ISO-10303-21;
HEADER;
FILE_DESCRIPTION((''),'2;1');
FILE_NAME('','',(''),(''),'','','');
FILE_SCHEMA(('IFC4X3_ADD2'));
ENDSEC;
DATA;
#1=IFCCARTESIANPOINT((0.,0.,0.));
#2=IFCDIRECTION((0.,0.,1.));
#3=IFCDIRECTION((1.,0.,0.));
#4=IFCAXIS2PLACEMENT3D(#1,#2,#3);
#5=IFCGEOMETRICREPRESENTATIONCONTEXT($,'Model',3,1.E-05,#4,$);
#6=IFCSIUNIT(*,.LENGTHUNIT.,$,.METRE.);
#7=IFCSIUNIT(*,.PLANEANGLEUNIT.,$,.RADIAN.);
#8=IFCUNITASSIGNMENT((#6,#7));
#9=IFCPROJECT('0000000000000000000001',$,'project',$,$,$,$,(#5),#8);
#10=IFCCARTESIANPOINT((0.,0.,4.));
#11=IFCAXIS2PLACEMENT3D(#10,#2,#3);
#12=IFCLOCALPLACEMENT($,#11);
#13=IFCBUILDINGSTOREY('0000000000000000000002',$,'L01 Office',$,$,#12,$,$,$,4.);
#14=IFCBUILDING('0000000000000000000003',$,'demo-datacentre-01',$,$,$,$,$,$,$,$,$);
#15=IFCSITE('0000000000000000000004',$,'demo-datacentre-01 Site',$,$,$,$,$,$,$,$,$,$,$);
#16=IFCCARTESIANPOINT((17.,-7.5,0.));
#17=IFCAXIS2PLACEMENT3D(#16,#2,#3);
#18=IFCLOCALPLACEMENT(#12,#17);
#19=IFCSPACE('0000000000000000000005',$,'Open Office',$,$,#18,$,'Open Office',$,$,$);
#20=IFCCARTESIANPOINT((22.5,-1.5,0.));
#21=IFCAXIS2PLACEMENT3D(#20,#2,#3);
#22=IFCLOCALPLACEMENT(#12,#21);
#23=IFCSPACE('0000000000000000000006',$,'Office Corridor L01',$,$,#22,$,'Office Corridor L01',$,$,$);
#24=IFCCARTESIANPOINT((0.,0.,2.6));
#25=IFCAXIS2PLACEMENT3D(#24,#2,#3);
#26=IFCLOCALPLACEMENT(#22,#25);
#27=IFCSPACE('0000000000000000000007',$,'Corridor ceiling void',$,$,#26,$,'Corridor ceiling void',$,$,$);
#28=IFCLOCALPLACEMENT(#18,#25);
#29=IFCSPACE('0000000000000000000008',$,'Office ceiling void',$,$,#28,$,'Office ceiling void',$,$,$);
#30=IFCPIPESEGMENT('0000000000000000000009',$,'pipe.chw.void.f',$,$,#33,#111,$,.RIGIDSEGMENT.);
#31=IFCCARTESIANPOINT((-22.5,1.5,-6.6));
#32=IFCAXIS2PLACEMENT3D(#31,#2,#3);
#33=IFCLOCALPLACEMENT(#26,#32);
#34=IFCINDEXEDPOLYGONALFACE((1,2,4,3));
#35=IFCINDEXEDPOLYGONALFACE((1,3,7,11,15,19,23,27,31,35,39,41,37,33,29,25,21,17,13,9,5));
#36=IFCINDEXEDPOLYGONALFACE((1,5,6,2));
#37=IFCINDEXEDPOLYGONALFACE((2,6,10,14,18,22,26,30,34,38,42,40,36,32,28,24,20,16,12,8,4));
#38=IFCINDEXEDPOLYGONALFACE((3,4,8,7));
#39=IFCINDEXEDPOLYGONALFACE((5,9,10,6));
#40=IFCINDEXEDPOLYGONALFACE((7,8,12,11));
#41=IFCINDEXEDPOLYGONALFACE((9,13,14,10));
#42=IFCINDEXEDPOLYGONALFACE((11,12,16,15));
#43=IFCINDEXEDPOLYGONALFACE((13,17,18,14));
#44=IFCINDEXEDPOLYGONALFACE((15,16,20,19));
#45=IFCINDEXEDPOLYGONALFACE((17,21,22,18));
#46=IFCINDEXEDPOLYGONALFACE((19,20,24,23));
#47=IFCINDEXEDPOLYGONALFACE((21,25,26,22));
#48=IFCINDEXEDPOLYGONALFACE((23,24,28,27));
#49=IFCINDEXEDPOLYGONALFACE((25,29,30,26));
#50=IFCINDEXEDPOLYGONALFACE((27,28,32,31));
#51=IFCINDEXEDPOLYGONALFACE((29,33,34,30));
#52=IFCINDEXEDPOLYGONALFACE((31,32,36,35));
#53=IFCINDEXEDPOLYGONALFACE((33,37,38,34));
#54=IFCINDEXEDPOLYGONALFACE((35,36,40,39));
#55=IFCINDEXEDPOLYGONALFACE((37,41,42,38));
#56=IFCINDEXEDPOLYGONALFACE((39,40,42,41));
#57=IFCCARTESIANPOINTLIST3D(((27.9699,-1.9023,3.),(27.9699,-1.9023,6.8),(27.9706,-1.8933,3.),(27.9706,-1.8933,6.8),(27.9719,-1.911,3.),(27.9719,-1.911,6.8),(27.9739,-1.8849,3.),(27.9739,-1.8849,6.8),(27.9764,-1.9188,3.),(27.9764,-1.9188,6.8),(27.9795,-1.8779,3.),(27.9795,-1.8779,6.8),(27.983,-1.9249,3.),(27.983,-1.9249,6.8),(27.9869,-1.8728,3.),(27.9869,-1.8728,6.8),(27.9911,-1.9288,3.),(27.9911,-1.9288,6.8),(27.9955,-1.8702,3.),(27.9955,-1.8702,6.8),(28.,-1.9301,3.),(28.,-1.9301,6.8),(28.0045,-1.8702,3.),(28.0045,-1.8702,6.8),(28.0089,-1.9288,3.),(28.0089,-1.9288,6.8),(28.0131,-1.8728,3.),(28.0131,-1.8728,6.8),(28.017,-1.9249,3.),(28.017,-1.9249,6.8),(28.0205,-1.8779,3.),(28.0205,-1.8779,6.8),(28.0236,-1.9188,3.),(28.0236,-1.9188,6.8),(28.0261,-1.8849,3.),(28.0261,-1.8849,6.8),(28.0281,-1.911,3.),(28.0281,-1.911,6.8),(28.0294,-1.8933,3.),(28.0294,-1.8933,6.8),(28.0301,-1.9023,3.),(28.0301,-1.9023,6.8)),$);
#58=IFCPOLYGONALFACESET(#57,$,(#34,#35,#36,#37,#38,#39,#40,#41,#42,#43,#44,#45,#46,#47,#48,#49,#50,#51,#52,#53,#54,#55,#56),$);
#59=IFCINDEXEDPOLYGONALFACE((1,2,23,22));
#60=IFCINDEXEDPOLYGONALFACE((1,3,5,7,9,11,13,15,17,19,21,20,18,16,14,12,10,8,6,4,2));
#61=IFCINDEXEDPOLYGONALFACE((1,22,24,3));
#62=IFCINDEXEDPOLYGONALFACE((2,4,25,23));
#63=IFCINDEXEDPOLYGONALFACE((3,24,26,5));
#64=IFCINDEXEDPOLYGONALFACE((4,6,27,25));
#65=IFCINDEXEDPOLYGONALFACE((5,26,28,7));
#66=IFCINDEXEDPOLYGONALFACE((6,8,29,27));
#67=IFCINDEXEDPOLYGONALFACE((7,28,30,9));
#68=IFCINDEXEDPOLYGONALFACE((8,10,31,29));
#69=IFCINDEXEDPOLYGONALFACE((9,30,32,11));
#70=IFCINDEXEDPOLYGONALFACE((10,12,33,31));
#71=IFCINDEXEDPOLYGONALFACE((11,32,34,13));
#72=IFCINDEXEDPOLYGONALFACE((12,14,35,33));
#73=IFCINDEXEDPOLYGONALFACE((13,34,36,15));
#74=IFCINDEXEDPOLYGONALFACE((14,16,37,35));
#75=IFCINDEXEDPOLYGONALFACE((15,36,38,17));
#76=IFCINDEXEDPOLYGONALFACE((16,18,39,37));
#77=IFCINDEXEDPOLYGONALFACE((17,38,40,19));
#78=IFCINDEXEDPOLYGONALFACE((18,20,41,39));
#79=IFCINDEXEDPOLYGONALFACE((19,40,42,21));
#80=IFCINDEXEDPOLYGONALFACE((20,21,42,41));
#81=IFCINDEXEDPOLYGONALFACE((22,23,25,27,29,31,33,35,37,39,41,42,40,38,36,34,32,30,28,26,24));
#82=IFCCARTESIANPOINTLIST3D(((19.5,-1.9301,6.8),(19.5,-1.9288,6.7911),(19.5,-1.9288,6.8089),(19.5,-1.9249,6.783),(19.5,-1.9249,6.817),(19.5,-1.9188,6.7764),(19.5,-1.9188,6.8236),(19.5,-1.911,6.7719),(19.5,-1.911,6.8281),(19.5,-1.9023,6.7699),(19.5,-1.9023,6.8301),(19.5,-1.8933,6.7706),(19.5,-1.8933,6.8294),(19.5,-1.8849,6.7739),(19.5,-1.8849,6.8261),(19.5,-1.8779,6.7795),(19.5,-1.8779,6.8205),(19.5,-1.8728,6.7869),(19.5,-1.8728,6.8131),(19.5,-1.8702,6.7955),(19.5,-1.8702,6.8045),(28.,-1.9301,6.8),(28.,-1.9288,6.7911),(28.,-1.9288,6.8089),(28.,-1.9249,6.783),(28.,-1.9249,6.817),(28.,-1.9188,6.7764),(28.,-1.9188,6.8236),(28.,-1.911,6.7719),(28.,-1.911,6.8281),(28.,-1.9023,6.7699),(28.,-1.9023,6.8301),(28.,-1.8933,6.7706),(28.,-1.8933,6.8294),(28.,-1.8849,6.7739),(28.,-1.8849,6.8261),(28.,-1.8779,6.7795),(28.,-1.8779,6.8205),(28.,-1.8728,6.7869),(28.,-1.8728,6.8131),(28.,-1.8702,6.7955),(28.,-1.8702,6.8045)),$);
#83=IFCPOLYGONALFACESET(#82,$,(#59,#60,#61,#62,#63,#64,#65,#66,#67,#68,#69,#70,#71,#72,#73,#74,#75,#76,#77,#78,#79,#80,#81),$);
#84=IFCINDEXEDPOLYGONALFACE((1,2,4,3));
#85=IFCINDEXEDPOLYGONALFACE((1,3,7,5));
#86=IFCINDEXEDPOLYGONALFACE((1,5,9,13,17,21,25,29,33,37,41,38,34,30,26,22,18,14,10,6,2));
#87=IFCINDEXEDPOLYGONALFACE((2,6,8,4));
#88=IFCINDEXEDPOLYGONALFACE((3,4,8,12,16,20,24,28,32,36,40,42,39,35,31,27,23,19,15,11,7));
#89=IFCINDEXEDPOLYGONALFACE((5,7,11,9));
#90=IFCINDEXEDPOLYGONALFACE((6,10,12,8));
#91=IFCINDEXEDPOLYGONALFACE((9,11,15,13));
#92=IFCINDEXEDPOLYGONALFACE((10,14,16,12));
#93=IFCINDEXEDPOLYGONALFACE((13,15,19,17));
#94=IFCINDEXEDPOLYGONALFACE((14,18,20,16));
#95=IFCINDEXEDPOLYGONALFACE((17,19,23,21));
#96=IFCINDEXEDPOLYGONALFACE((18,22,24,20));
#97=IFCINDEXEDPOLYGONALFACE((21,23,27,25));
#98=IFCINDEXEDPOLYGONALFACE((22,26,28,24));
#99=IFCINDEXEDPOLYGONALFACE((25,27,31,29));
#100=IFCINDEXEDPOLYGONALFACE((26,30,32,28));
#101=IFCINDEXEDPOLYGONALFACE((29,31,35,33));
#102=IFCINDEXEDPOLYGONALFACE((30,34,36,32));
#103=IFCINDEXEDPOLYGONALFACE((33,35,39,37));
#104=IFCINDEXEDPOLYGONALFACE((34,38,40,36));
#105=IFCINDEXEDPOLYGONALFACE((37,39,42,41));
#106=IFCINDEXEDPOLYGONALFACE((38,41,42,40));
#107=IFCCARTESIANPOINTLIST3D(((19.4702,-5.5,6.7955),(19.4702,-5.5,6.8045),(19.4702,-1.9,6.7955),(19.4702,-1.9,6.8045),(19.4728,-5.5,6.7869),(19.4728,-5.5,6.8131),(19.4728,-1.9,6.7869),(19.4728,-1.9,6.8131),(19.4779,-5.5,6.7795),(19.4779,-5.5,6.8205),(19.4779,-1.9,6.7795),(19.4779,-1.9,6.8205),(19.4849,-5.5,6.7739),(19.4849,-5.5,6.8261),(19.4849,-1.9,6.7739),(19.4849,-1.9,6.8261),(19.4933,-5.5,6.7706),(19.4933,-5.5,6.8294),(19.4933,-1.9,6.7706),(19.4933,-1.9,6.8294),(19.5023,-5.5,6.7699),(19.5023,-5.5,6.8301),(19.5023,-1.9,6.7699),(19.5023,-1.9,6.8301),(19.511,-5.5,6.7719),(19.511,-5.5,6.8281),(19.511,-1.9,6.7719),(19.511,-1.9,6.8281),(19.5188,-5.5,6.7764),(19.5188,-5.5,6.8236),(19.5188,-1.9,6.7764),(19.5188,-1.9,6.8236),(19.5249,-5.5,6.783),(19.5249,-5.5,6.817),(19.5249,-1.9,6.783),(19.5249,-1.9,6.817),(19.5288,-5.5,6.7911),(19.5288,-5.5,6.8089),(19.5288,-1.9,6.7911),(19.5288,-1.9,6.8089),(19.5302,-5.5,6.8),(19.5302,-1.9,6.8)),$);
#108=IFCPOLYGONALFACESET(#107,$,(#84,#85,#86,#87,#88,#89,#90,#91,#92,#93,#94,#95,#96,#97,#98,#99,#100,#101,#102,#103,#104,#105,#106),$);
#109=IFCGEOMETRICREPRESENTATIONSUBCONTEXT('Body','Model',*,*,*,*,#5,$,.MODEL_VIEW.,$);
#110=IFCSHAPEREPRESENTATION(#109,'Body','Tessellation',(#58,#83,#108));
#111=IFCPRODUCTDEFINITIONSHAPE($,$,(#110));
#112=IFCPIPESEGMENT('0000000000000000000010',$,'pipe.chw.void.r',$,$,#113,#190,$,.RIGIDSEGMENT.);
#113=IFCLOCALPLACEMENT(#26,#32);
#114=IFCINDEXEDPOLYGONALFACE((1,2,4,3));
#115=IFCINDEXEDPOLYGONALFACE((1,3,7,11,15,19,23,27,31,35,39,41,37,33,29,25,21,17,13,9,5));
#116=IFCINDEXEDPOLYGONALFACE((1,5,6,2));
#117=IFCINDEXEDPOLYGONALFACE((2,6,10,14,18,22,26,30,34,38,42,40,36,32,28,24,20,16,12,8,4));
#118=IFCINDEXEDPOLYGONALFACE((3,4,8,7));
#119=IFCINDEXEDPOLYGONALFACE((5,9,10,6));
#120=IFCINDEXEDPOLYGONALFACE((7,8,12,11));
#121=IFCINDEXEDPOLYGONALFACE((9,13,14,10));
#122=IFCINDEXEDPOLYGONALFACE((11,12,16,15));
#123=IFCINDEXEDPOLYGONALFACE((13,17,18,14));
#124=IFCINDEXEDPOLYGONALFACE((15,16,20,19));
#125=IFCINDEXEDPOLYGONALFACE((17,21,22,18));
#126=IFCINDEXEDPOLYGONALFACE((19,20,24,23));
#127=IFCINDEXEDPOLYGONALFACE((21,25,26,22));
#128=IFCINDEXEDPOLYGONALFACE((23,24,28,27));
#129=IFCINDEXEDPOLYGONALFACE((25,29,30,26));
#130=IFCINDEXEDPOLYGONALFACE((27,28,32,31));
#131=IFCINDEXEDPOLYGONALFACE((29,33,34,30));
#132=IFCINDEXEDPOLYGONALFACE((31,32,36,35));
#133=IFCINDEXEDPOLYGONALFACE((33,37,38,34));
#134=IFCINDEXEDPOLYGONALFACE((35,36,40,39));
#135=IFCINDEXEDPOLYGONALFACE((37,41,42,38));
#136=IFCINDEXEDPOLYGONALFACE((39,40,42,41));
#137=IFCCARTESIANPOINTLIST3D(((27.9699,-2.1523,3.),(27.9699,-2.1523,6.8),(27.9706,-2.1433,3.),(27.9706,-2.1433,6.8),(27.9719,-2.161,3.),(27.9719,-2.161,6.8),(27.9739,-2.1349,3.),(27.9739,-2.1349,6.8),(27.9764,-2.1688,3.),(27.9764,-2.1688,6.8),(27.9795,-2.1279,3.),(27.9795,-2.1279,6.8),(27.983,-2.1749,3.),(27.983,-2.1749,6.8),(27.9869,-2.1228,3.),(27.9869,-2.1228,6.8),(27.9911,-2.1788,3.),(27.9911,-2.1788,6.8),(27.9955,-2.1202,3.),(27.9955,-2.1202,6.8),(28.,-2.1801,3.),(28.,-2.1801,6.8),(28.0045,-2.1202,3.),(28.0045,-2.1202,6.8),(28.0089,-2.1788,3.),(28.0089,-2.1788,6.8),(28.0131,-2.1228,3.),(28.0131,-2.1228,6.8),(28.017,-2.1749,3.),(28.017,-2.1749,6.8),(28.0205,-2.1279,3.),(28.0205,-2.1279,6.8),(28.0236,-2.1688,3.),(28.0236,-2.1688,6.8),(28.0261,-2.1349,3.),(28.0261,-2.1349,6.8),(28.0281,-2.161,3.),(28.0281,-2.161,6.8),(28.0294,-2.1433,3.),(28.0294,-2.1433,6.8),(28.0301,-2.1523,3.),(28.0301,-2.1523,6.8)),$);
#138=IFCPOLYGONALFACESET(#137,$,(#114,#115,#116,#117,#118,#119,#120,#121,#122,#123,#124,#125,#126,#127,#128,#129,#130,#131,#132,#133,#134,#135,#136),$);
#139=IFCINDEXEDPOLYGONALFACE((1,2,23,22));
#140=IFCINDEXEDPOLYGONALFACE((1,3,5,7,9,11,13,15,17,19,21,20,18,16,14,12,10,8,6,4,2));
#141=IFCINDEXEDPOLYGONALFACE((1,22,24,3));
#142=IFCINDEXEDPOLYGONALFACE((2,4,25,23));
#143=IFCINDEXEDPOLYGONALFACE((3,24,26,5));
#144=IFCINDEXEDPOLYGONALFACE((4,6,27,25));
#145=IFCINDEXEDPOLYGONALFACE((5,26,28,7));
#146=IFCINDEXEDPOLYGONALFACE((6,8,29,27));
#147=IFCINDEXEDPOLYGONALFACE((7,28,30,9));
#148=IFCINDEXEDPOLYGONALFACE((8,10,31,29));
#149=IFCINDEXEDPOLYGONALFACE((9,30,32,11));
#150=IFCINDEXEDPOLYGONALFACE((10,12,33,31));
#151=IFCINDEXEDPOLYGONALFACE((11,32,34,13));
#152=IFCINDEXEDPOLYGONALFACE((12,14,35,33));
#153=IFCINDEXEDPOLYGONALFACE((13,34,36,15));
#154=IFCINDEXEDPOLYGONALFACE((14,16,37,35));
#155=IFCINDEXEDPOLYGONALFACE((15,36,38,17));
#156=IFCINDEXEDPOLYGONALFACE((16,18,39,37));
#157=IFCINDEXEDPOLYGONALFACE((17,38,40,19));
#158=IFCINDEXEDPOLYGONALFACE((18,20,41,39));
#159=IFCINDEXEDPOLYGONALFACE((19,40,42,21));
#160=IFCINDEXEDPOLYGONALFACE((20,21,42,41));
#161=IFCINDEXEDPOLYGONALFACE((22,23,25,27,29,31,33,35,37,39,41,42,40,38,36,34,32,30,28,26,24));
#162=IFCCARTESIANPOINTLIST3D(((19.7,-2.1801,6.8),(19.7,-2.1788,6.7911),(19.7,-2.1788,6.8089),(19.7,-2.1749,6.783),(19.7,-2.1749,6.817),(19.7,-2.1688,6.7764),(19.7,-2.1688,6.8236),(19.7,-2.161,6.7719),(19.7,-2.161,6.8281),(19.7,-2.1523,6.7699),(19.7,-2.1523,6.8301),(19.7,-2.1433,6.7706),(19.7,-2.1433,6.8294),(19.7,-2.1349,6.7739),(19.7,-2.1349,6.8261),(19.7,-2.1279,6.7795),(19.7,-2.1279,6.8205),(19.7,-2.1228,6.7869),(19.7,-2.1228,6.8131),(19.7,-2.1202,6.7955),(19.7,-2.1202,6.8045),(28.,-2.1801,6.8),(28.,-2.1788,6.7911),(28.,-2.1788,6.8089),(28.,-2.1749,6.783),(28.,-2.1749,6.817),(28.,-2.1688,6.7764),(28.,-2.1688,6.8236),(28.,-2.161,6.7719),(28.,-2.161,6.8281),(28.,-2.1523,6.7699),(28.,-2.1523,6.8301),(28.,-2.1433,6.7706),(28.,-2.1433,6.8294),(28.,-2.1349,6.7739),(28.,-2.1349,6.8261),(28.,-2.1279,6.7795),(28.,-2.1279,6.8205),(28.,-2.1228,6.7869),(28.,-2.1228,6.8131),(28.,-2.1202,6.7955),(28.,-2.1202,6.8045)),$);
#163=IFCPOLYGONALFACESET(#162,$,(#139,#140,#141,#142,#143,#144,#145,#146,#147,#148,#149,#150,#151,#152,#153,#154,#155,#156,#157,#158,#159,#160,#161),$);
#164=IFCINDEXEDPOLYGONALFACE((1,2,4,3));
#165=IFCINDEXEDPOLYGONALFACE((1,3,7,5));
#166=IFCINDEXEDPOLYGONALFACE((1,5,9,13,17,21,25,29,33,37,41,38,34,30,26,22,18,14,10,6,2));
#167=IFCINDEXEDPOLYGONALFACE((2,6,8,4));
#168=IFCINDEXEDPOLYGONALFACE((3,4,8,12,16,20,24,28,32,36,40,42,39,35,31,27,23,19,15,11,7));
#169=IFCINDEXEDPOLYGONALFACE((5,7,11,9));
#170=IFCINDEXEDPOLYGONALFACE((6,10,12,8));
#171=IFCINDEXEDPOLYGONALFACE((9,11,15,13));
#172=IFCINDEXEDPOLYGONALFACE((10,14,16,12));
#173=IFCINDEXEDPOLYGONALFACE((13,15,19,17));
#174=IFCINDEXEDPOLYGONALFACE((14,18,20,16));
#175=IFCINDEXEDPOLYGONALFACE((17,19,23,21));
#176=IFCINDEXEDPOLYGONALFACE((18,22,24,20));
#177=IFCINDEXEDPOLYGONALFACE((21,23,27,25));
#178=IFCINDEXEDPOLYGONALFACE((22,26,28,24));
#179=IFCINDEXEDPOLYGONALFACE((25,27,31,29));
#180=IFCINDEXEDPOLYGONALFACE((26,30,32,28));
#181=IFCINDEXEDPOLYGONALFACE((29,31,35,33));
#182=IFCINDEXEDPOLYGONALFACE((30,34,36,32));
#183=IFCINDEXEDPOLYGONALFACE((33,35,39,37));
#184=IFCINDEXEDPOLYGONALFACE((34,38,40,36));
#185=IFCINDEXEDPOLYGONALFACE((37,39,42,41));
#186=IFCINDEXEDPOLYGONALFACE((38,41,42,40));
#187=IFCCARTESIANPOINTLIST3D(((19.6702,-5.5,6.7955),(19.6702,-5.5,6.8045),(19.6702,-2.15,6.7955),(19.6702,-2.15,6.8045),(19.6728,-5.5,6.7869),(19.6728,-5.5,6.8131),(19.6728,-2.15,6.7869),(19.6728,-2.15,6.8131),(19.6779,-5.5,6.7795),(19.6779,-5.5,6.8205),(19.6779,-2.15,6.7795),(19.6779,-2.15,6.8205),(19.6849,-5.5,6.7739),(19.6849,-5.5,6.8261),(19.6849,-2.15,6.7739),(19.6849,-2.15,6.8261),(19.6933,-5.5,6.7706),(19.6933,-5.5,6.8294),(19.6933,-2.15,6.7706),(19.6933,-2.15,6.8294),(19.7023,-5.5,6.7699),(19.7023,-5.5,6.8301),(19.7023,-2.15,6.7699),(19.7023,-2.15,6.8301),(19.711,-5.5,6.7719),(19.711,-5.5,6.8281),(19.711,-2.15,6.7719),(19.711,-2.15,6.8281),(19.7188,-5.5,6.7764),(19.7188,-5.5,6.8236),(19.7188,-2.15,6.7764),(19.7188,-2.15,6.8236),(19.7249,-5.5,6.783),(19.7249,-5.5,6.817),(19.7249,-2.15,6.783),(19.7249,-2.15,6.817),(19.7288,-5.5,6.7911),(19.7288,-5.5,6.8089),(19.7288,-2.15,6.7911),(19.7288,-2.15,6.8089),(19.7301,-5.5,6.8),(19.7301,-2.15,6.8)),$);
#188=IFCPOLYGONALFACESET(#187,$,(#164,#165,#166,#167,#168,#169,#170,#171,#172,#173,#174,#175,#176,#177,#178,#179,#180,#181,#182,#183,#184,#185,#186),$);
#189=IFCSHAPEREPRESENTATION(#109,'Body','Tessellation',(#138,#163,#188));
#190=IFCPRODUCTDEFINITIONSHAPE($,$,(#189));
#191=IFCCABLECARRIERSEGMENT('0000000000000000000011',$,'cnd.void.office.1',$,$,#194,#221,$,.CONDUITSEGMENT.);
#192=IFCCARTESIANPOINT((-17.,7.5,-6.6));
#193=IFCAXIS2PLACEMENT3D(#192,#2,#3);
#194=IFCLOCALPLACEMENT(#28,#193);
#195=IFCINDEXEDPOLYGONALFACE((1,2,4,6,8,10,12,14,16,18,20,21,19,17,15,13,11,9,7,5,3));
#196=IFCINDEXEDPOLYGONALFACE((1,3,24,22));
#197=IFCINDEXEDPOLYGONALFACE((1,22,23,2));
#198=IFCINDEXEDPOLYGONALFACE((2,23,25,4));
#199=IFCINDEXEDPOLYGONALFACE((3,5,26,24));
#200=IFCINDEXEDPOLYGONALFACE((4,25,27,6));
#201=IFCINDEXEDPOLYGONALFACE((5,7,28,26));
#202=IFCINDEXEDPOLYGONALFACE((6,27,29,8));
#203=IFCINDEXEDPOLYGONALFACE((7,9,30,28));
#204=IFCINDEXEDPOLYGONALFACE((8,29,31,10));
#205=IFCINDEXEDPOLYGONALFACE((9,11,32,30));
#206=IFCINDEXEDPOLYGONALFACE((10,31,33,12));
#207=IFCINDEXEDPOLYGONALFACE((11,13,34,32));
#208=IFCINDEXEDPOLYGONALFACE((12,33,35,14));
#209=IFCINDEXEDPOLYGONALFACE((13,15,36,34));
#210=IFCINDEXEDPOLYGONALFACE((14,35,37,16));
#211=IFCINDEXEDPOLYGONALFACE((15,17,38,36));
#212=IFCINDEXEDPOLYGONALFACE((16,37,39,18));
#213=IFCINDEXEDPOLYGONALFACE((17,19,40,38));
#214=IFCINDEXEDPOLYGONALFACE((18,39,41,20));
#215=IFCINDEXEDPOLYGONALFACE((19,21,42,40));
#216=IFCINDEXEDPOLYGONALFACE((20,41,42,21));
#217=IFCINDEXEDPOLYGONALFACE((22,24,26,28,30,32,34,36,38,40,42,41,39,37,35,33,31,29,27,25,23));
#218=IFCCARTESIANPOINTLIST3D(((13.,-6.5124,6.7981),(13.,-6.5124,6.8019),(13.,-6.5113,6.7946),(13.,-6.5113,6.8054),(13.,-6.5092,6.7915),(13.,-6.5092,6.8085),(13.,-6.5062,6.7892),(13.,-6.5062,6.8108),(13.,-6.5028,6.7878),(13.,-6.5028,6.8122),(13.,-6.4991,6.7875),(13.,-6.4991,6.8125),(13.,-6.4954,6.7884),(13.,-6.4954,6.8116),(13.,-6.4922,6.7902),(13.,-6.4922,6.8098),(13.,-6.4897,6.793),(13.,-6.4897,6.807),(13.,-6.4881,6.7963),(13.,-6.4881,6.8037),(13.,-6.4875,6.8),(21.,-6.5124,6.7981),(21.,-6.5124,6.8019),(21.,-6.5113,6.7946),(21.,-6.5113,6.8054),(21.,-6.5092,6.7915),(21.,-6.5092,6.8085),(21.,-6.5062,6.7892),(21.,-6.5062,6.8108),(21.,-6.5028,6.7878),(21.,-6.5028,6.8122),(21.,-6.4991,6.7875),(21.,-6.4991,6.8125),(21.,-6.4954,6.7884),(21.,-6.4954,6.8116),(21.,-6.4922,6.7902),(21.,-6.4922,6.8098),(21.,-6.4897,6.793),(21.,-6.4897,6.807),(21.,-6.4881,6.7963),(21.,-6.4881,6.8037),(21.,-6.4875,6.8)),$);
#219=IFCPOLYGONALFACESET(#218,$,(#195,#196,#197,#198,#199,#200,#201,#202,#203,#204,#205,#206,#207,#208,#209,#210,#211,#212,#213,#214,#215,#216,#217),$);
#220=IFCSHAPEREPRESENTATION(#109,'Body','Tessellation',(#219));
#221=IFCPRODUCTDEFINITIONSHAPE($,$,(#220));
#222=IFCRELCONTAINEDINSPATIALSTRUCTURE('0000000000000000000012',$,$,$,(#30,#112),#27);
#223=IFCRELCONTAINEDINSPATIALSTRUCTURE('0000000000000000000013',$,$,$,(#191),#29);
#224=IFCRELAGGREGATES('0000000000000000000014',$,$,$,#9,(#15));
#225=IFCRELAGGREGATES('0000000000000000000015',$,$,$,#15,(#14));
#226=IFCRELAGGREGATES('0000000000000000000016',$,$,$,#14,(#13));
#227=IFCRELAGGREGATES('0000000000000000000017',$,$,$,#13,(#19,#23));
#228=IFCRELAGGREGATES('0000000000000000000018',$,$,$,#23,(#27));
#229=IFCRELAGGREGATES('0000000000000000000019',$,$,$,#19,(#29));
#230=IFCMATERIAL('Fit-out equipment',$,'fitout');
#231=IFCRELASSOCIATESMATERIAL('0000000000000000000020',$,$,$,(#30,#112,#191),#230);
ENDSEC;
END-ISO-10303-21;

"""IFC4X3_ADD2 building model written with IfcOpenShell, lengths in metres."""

from ifc_helpers import new_model, si_unit, frame, origin_with_axes, place, context, subcontext, project, spatial, circle, extrude, material, element, save


model = new_model("IFC4X3_ADD2")

# Units and contexts
model_context = context("Model", 3, precision=1e-05, world=origin_with_axes())
body_context = subcontext(model_context, "Body", "Model", "MODEL_VIEW")
ifc_project = project(units=[si_unit("LENGTHUNIT", "METRE"), si_unit("PLANEANGLEUNIT", "RADIAN")], contexts=[model_context])

# Site, building, storey, space
site = spatial("IfcSite", under=ifc_project, Name="demo-datacentre-01 Site")
building = spatial("IfcBuilding", under=site, Name="demo-datacentre-01")
storey_placement = place(None, frame((0.0, 0.0, 4.0), z_axis=(0.0, 0.0, 1.0), x_axis=(1.0, 0.0, 0.0)))
storey = spatial("IfcBuildingStorey", under=building, at=storey_placement, Name="L01 Office", Elevation=4.0)
space_1_placement = place(storey_placement, frame((17.0, -7.5, 0.0), z_axis=(0.0, 0.0, 1.0), x_axis=(1.0, 0.0, 0.0)))
space_1 = spatial("IfcSpace", under=storey, at=space_1_placement, Name="Open Office", LongName="Open Office")

# Shared definitions
space_2_placement = place(storey_placement, frame((22.5, -1.5, 0.0), z_axis=(0.0, 0.0, 1.0), x_axis=(1.0, 0.0, 0.0)))
space_2 = spatial("IfcSpace", under=storey, at=space_2_placement, Name="Office Corridor L01", LongName="Office Corridor L01")

# Shared definitions
space_3_placement = place(space_2_placement, frame((0.0, 0.0, 2.6), z_axis=(0.0, 0.0, 1.0), x_axis=(1.0, 0.0, 0.0)))
space_3 = spatial("IfcSpace", under=space_2, at=space_3_placement, Name="Corridor ceiling void", LongName="Corridor ceiling void")

# Shared definitions
ifc_material_1 = material(Name="Fit-out equipment", Category="fitout")

# Pipe segments
pipe_segment_1_placement = place(space_3_placement, frame((-22.5, 1.5, -6.6), z_axis=(0.0, 0.0, 1.0), x_axis=(1.0, 0.0, 0.0)))
element("IfcPipeSegment", 1, at=pipe_segment_1_placement, inside=space_3, material=ifc_material_1, Name="pipe.chw.void.f", PredefinedType="RIGIDSEGMENT", context=body_context, shape_type="SweptSolid", body=[
    extrude(circle(Radius=0.0301), frame((28.0, -1.9, 3.0), z_axis=(0.0, 0.0, 1.0), x_axis=(0.0, -1.0, 0.0)), (0.0, 0.0, 1.0), 3.8),
    extrude(circle(Radius=0.0301), frame((28.0, -1.9, 6.8), z_axis=(-1.0, 0.0, 0.0), x_axis=(0.0, -1.0, 0.0)), (0.0, 0.0, 1.0), 8.5),
    extrude(circle(Radius=0.0301), frame((19.5, -1.9, 6.8), z_axis=(0.0, -1.0, 0.0), x_axis=(1.0, 0.0, 0.0)), (0.0, 0.0, 1.0), 3.6),
])
pipe_segment_2_placement = place(space_3_placement, frame((-22.5, 1.5, -6.6), z_axis=(0.0, 0.0, 1.0), x_axis=(1.0, 0.0, 0.0)))
element("IfcPipeSegment", 2, at=pipe_segment_2_placement, inside=space_3, material=ifc_material_1, Name="pipe.chw.void.r", PredefinedType="RIGIDSEGMENT", context=body_context, shape_type="SweptSolid", body=[
    extrude(circle(Radius=0.0301), frame((28.0, -2.15, 3.0), z_axis=(0.0, 0.0, 1.0), x_axis=(0.0, -1.0, 0.0)), (0.0, 0.0, 1.0), 3.8),
    extrude(circle(Radius=0.0301), frame((28.0, -2.15, 6.8), z_axis=(-1.0, 0.0, 0.0), x_axis=(0.0, -1.0, 0.0)), (0.0, 0.0, 1.0), 8.3),
    extrude(circle(Radius=0.0301), frame((19.7, -2.15, 6.8), z_axis=(0.0, -1.0, 0.0), x_axis=(1.0, 0.0, 0.0)), (0.0, 0.0, 1.0), 3.35),
])

# Shared definitions
space_4_placement = place(space_1_placement, frame((0.0, 0.0, 2.6), z_axis=(0.0, 0.0, 1.0), x_axis=(1.0, 0.0, 0.0)))
space_4 = spatial("IfcSpace", under=space_1, at=space_4_placement, Name="Office ceiling void", LongName="Office ceiling void")

# Cable carrier segment
cable_carrier_segment_1_placement = place(space_4_placement, frame((-17.0, 7.5, -6.6), z_axis=(0.0, 0.0, 1.0), x_axis=(1.0, 0.0, 0.0)))
element("IfcCableCarrierSegment", 3, at=cable_carrier_segment_1_placement, inside=space_4, material=ifc_material_1, Name="cnd.void.office.1", PredefinedType="CONDUITSEGMENT", context=body_context, shape_type="SweptSolid", body=[
    extrude(circle(Radius=0.0125), frame((13.0, -6.5, 6.8), z_axis=(1.0, 0.0, 0.0), x_axis=(0.0, 1.0, 0.0)), (0.0, 0.0, 1.0), 8.0),
])

save(model, "model.ifc")
